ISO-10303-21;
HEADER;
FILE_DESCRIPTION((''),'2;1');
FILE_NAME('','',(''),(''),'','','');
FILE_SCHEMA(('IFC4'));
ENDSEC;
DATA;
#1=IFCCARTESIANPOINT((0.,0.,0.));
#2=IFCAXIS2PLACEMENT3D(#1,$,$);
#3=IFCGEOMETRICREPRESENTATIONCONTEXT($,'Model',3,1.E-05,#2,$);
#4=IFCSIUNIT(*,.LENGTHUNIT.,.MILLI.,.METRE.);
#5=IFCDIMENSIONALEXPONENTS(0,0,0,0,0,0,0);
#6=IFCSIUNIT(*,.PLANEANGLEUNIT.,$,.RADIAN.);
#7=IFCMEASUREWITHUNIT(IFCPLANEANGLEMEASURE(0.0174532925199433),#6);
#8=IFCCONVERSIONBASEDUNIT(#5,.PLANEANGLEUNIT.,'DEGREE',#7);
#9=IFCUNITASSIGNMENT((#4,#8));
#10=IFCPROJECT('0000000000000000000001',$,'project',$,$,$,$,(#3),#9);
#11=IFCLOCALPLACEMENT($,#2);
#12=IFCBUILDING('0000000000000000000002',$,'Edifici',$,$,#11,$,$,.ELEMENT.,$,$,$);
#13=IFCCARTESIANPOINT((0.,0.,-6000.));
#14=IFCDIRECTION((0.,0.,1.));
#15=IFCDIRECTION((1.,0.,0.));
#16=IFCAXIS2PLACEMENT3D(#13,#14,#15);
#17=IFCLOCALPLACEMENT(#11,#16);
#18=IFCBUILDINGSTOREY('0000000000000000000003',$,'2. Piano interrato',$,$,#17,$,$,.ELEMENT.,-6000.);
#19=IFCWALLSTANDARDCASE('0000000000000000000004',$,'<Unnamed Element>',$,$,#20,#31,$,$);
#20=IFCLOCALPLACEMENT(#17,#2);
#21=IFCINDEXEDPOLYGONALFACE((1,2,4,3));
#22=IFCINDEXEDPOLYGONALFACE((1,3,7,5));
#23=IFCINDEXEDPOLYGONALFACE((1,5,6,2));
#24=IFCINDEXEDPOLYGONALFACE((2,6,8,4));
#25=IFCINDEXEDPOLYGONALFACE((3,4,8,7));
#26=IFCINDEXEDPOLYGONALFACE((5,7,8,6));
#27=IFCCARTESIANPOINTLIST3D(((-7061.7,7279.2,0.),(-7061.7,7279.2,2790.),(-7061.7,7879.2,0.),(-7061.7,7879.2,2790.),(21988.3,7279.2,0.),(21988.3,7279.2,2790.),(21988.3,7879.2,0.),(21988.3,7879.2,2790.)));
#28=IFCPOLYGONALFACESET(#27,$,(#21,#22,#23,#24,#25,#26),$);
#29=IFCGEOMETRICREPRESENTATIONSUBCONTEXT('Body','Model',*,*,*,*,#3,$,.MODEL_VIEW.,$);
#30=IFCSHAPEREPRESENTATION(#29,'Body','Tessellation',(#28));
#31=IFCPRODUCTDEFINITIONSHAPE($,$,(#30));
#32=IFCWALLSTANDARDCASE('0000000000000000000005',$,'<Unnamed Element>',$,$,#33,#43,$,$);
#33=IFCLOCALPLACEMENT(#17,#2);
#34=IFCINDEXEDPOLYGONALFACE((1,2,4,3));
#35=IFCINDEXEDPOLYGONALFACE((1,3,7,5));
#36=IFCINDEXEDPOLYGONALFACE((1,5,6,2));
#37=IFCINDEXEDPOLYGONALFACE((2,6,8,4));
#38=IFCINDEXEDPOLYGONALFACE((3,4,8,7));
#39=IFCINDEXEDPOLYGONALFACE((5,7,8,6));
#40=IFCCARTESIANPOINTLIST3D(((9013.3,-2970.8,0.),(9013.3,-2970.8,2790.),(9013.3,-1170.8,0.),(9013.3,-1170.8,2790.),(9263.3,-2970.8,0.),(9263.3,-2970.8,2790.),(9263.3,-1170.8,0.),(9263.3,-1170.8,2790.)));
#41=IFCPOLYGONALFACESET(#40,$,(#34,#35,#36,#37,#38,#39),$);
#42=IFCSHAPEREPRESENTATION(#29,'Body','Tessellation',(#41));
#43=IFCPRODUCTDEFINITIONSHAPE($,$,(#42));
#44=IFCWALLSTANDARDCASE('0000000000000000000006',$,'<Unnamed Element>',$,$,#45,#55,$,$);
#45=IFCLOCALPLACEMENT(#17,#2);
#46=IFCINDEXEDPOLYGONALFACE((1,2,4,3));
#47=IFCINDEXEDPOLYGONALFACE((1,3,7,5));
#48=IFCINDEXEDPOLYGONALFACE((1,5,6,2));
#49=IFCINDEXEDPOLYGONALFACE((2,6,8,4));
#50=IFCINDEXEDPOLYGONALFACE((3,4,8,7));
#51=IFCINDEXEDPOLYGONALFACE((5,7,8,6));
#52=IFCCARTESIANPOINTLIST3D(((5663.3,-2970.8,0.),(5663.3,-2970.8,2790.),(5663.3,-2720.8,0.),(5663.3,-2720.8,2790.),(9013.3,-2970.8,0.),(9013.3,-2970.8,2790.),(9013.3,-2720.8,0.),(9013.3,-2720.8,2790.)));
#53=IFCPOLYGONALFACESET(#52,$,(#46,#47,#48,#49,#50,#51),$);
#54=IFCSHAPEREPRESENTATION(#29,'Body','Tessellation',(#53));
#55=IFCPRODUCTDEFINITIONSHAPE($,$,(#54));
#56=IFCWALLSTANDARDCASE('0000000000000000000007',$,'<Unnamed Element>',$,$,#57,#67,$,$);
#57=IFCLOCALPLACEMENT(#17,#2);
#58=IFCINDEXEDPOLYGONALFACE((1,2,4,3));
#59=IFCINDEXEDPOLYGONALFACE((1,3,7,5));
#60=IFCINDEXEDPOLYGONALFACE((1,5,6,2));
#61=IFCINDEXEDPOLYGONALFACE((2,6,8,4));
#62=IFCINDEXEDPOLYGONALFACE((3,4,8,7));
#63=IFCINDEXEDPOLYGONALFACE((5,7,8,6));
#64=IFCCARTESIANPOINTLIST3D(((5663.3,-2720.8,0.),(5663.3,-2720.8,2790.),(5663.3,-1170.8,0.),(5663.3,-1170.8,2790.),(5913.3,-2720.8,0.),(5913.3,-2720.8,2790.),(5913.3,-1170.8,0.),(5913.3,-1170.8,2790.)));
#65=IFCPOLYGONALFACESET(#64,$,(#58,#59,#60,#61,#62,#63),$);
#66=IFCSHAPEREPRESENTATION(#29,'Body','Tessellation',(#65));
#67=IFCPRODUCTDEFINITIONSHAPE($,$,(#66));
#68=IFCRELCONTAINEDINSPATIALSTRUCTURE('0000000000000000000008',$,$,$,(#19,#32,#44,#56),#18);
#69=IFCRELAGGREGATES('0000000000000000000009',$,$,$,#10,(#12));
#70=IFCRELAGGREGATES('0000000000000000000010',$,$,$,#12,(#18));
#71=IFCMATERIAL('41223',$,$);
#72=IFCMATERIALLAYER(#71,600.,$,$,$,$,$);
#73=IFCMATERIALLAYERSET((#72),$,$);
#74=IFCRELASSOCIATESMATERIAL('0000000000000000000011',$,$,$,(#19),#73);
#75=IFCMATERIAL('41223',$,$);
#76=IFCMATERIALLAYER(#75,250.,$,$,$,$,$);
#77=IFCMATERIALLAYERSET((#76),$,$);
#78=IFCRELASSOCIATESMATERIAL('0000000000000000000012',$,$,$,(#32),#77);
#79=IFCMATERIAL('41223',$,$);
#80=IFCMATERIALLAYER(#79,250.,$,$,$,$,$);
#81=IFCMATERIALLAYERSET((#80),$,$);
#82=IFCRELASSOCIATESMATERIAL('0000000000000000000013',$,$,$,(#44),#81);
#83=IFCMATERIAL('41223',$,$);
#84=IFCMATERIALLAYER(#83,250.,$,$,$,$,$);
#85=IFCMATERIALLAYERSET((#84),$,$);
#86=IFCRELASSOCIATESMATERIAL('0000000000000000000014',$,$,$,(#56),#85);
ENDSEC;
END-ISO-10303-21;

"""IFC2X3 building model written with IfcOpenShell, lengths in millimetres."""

from ifc_helpers import new_model, entity, si_unit, converted_unit, frame, frame_2d, origin, origin_with_axes, place, context, subcontext, project, spatial, rectangle, extrude, material, layer, layer_set, layer_usage, element, save


model = new_model("IFC2X3")

# Units and contexts
model_context = context("Model", 3, precision=1e-05, world=origin())
body_context = subcontext(model_context, "Body", "Model", "MODEL_VIEW")
ifc_project = project(units=[si_unit("LENGTHUNIT", "METRE", prefix="MILLI"), converted_unit("PLANEANGLEUNIT", "DEGREE", entity("IfcPlaneAngleMeasure", 0.0174532925199433), si_unit("PLANEANGLEUNIT", "RADIAN"), dimensions=[0, 0, 0, 0, 0, 0, 0])], contexts=[model_context])

# Building, storey
building_placement = place(None, origin())
building = spatial("IfcBuilding", under=ifc_project, at=building_placement, Name="Edifici", CompositionType="ELEMENT")
storey_placement = place(building_placement, frame((0.0, 0.0, -6000.0), z_axis=(0.0, 0.0, 1.0), x_axis=(1.0, 0.0, 0.0)))
storey = spatial("IfcBuildingStorey", under=building, at=storey_placement, Name="2. Piano interrato", CompositionType="ELEMENT", Elevation=-6000.0)

# Walls
ifc_material_1 = material(Name="41223")
ifc_layer_1 = layer(ifc_material_1, 600.0)
ifc_layer_set_1 = layer_set([ifc_layer_1])
ifc_layer_usage_1 = layer_usage(ifc_layer_set_1, "AXIS2", "POSITIVE", 0.0)
wall_1_placement = place(storey_placement, frame((21988.3, 7879.2, 0.0), z_axis=(0.0, 0.0, 1.0), x_axis=(-1.0, 0.0, 0.0)))
element("IfcWallStandardCase", 1, at=wall_1_placement, inside=storey, material=ifc_layer_usage_1, Name="<Unnamed Element>", context=body_context, shape_type="SweptSolid", body=[
    extrude(rectangle(XDim=29050.0, YDim=600.0, at=frame_2d((14525.0, 300.0), x_axis=(1.0, 0.0))), origin_with_axes(), (0.0, 0.0, 1.0), 2790.0),
])
ifc_material_2 = material(Name="41223")
ifc_layer_2 = layer(ifc_material_2, 250.0)
ifc_layer_set_2 = layer_set([ifc_layer_2])
ifc_layer_usage_2 = layer_usage(ifc_layer_set_2, "AXIS2", "POSITIVE", 0.0)
wall_2_placement = place(storey_placement, frame((9263.3, -2970.8, 0.0), z_axis=(0.0, 0.0, 1.0), x_axis=(0.0, 1.0, 0.0)))
element("IfcWallStandardCase", 2, at=wall_2_placement, inside=storey, material=ifc_layer_usage_2, Name="<Unnamed Element>", context=body_context, shape_type="SweptSolid", body=[
    extrude(rectangle(XDim=1800.0, YDim=250.0, at=frame_2d((900.0, 125.0), x_axis=(1.0, 0.0))), origin_with_axes(), (0.0, 0.0, 1.0), 2790.0),
])
ifc_material_3 = material(Name="41223")
ifc_layer_3 = layer(ifc_material_3, 250.0)
ifc_layer_set_3 = layer_set([ifc_layer_3])
ifc_layer_usage_3 = layer_usage(ifc_layer_set_3, "AXIS2", "POSITIVE", 0.0)
wall_3_placement = place(storey_placement, frame((5663.3, -2970.8, 0.0), z_axis=(0.0, 0.0, 1.0), x_axis=(1.0, 0.0, 0.0)))
element("IfcWallStandardCase", 3, at=wall_3_placement, inside=storey, material=ifc_layer_usage_3, Name="<Unnamed Element>", context=body_context, shape_type="SweptSolid", body=[
    extrude(rectangle(XDim=3350.0, YDim=250.0, at=frame_2d((1675.0, 125.0), x_axis=(1.0, 0.0))), origin_with_axes(), (0.0, 0.0, 1.0), 2790.0),
])
ifc_material_4 = material(Name="41223")
ifc_layer_4 = layer(ifc_material_4, 250.0)
ifc_layer_set_4 = layer_set([ifc_layer_4])
ifc_layer_usage_4 = layer_usage(ifc_layer_set_4, "AXIS2", "POSITIVE", 0.0)
wall_4_placement = place(storey_placement, frame((5663.3, -1170.8, 0.0), z_axis=(0.0, 0.0, 1.0), x_axis=(0.0, -1.0, 0.0)))
element("IfcWallStandardCase", 4, at=wall_4_placement, inside=storey, material=ifc_layer_usage_4, Name="<Unnamed Element>", context=body_context, shape_type="SweptSolid", body=[
    extrude(rectangle(XDim=1550.0, YDim=250.0, at=frame_2d((775.0, 125.0), x_axis=(1.0, 0.0))), origin_with_axes(), (0.0, 0.0, 1.0), 2790.0),
])

save(model, "model.ifc")
